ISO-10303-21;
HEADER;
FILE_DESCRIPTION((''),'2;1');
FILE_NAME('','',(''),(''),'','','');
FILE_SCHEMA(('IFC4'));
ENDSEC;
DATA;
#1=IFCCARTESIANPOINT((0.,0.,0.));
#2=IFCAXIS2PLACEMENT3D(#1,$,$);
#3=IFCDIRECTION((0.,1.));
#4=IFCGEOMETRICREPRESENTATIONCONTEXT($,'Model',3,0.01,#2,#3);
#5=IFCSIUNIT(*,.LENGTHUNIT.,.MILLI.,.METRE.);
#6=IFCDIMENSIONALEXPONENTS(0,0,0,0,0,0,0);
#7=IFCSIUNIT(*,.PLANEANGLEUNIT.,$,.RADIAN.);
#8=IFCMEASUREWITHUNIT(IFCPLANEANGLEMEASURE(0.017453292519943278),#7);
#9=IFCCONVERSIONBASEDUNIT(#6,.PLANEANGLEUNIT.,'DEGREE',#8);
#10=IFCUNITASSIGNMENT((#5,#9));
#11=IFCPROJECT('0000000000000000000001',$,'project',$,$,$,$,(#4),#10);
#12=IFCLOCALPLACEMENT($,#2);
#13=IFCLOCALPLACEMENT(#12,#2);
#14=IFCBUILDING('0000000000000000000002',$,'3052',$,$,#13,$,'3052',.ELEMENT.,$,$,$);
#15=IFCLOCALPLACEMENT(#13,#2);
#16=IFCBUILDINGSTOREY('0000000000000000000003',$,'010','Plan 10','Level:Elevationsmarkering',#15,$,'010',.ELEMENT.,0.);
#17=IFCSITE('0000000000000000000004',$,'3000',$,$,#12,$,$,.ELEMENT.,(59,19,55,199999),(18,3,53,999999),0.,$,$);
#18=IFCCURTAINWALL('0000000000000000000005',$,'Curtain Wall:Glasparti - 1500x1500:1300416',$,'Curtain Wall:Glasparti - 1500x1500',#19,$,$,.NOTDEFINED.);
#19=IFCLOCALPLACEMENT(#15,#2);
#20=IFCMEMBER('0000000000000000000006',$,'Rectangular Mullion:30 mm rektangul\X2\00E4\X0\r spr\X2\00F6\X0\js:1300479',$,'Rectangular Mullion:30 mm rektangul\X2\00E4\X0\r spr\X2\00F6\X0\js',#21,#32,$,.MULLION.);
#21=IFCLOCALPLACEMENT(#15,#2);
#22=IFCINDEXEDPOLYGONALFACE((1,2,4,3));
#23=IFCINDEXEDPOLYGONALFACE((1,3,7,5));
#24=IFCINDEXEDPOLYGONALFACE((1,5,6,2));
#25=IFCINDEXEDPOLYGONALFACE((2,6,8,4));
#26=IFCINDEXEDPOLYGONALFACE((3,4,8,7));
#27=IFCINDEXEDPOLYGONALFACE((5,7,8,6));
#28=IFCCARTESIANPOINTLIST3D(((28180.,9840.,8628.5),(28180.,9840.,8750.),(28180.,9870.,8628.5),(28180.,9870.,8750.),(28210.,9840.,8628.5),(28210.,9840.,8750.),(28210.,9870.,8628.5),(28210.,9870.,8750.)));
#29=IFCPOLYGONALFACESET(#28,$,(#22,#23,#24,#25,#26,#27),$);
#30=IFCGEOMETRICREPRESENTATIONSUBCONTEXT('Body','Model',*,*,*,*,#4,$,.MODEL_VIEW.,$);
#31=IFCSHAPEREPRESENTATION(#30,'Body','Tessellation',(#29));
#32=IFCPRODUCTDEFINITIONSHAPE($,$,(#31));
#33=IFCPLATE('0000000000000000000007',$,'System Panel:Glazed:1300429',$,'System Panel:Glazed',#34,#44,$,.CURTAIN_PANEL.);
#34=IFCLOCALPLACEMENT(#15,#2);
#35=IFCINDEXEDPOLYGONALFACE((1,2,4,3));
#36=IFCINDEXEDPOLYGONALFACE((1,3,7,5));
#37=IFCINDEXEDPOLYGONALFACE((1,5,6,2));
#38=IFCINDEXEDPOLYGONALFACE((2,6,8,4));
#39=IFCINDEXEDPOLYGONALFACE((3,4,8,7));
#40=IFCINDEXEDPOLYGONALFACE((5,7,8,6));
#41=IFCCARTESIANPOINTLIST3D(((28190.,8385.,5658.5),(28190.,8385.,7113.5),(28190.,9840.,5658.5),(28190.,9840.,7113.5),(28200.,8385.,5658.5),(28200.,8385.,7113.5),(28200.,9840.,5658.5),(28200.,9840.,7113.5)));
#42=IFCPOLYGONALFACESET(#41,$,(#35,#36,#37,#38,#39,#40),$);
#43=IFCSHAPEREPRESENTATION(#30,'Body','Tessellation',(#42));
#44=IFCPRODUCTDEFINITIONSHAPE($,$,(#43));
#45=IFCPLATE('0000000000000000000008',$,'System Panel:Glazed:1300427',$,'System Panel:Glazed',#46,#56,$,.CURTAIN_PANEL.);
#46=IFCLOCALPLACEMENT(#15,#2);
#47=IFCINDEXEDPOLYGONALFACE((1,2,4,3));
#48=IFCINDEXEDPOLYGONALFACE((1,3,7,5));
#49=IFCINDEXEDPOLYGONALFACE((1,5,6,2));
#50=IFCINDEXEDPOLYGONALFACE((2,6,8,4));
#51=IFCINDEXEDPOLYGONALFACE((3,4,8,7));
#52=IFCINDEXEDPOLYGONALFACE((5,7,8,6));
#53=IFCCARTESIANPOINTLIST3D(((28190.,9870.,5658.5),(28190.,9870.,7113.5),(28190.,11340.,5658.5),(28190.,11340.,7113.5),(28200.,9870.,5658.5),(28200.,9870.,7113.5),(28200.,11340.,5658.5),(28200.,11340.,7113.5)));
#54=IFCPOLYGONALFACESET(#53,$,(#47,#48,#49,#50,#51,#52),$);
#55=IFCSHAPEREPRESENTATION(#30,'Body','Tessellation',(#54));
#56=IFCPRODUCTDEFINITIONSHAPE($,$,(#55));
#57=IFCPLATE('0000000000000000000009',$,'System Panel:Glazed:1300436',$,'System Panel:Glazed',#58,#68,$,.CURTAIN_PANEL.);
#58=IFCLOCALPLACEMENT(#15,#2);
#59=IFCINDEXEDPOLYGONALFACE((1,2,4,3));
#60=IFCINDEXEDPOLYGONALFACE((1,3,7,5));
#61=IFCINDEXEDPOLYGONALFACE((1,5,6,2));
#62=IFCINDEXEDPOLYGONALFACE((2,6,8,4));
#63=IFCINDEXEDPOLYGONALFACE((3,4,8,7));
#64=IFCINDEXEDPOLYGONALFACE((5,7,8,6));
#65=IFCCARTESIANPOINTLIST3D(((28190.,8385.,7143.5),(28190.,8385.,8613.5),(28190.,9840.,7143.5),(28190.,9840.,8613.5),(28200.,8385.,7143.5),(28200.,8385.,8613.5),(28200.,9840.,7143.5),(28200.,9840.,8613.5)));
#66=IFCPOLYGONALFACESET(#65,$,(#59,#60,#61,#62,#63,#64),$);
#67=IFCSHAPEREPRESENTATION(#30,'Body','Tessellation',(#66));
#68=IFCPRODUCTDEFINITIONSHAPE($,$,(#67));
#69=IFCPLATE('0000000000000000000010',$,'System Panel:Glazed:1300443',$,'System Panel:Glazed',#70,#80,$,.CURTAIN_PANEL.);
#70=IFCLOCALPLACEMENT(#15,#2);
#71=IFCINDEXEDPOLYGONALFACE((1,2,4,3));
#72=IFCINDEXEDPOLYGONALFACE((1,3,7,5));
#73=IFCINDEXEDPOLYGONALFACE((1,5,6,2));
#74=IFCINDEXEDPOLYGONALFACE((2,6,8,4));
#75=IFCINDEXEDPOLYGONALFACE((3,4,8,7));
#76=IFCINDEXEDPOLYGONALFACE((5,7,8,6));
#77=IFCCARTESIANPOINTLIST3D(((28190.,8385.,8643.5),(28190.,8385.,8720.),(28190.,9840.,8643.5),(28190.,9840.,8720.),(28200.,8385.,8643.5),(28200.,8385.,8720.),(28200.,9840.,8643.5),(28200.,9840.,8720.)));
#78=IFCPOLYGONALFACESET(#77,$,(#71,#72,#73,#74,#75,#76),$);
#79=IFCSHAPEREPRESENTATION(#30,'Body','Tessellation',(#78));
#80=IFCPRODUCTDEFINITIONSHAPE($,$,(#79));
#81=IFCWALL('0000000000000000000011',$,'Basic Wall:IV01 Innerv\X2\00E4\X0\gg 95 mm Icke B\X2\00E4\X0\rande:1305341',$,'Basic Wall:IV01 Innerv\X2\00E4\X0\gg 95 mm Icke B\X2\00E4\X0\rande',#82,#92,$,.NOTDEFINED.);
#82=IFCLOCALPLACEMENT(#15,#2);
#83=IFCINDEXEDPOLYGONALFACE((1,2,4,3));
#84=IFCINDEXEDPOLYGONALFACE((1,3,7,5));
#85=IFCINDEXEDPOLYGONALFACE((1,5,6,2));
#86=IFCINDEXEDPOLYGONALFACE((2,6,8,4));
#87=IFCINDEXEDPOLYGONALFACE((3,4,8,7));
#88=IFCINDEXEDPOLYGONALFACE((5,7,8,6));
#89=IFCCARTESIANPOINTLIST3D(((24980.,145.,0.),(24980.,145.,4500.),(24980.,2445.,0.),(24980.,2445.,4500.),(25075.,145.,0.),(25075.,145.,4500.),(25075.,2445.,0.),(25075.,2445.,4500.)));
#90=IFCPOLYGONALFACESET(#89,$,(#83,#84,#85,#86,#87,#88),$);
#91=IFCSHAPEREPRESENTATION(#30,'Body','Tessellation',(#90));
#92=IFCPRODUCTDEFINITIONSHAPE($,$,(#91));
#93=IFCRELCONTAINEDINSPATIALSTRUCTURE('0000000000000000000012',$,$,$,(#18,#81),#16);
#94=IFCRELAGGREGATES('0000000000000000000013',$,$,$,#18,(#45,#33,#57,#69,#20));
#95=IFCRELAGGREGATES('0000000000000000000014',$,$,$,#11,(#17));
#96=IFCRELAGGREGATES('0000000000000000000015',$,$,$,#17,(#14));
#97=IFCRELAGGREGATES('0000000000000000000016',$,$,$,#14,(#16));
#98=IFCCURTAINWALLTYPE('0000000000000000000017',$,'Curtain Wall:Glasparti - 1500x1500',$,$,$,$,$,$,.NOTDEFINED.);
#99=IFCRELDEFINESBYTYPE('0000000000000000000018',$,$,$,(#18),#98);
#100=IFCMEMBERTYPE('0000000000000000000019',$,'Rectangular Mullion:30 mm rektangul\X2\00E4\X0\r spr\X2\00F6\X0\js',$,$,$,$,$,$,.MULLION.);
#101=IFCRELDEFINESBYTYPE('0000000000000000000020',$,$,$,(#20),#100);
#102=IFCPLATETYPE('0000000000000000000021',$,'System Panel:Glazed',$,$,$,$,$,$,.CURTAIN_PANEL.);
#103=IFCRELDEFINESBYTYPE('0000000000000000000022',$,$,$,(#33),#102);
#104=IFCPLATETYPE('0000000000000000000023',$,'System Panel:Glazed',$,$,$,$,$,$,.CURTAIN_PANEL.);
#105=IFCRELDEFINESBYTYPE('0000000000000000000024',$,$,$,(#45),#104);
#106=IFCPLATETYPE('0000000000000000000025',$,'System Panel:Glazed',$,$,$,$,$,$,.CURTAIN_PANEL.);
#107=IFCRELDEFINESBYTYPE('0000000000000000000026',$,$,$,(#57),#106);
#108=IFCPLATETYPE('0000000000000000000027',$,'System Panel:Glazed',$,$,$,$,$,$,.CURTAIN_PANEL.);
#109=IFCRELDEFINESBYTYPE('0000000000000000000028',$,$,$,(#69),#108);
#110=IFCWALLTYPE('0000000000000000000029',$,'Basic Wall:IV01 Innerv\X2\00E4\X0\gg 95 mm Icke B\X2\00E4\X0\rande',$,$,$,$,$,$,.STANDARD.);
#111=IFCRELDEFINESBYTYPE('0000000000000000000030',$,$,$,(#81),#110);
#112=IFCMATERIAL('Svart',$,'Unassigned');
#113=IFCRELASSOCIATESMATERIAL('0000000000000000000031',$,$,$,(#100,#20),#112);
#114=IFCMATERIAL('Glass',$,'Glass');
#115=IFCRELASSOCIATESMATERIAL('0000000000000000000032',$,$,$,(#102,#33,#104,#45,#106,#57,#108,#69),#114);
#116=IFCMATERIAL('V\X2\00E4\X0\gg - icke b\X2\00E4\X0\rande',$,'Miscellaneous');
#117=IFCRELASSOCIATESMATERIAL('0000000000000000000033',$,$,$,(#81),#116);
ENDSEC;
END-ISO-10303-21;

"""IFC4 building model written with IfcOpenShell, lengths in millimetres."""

from ifc_helpers import new_model, entity, si_unit, converted_unit, direction, frame, origin, place, context, subcontext, project, spatial, indexed_curve, outline, extrude, source, transform, mapped, material, type_object, type_shapes, element, aggregate, save


model = new_model("IFC4")

# Units and contexts
model_context = context("Model", 3, precision=0.01, world=origin(), true_north=direction((0.0, 1.0)))
body_context = subcontext(model_context, "Body", "Model", "MODEL_VIEW")
ifc_project = project(units=[si_unit("LENGTHUNIT", "METRE", prefix="MILLI"), converted_unit("PLANEANGLEUNIT", "DEGREE", entity("IfcPlaneAngleMeasure", 0.017453292519943278), si_unit("PLANEANGLEUNIT", "RADIAN"), dimensions=[0, 0, 0, 0, 0, 0, 0])], contexts=[model_context])

# Site, building, storey
site_placement = place(None, origin())
site = spatial("IfcSite", under=ifc_project, at=site_placement, Name="3000", CompositionType="ELEMENT", RefLatitude=(59, 19, 55, 199999), RefLongitude=(18, 3, 53, 999999), RefElevation=0.0)
building_placement = place(site_placement, origin())
building = spatial("IfcBuilding", under=site, at=building_placement, Name="3052", LongName="3052", CompositionType="ELEMENT")
storey_placement = place(building_placement, origin())
storey = spatial("IfcBuildingStorey", under=building, at=storey_placement, Name="010", Description="Plan 10", ObjectType="Level:Elevationsmarkering", LongName="010", CompositionType="ELEMENT", Elevation=0.0)

# Curtain wall, member, plates
curtain_wall_type = type_object("IfcCurtainWallType", Name="Curtain Wall:Glasparti - 1500x1500", PredefinedType="NOTDEFINED")
curtain_wall_placement = place(storey_placement, origin())
curtain_wall = element("IfcCurtainWall", 1, at=curtain_wall_placement, inside=storey, type_object=curtain_wall_type, Name="Curtain Wall:Glasparti - 1500x1500:1300416", ObjectType="Curtain Wall:Glasparti - 1500x1500", PredefinedType="NOTDEFINED")
ifc_material_1 = material(Name="Svart", Category="Unassigned")
member_type_1 = type_object("IfcMemberType", Name="Rectangular Mullion:30 mm rektangulär spröjs", PredefinedType="MULLION", material=ifc_material_1)
shared_shape_1 = source(origin(), body_context, "Body", "SweptSolid", [
    extrude(outline(indexed_curve([(-15.0, -15.0), (15.0, -15.0), (15.0, 15.0), (-15.0, 15.0), (-15.0, -15.0)], self_intersect=False)), frame((0.0, 0.0, -121.5), z_axis=(0.0, 0.0, 1.0), x_axis=(-1.0, 0.0, 0.0)), (0.0, 0.0, 1.0), 121.5),
])
type_shapes(member_type_1, [shared_shape_1])
member_1_placement = place(curtain_wall_placement, frame((28195.0, 9855.0, 8628.5), z_axis=(0.0, 0.0, -1.0), x_axis=(0.0, -1.0, 0.0)))
member_1 = element("IfcMember", 2, at=member_1_placement, type_object=member_type_1, material=ifc_material_1, Name="Rectangular Mullion:30 mm rektangulär spröjs:1300479", ObjectType="Rectangular Mullion:30 mm rektangulär spröjs", PredefinedType="MULLION", context=body_context, shape_type="MappedRepresentation", body=[
    mapped(shared_shape_1, transform((0.0, 0.0, 0.0), scale=1.0)),
])
ifc_material_2 = material(Name="Glass", Category="Glass")
plate_type_1 = type_object("IfcPlateType", Name="System Panel:Glazed", PredefinedType="CURTAIN_PANEL", material=ifc_material_2)
shared_shape_2 = source(origin(), body_context, "Body", "SweptSolid", [
    extrude(outline(indexed_curve([(-5.0, -727.5), (5.0, -727.5), (5.0, 727.5), (-5.0, 727.5), (-5.0, -727.5)], self_intersect=False)), frame((0.0, 0.0, 0.0), z_axis=(0.0, 0.0, 1.0), x_axis=(0.0, 1.0, 0.0)), (0.0, 0.0, 1.0), 1455.0),
])
type_shapes(plate_type_1, [shared_shape_2])
plate_1_placement = place(curtain_wall_placement, frame((28195.0, 9112.5, 5658.5), z_axis=(0.0, 0.0, 1.0), x_axis=(0.0, -1.0, 0.0)))
plate_1 = element("IfcPlate", 3, at=plate_1_placement, type_object=plate_type_1, material=ifc_material_2, Name="System Panel:Glazed:1300429", ObjectType="System Panel:Glazed", PredefinedType="CURTAIN_PANEL", context=body_context, shape_type="MappedRepresentation", body=[
    mapped(shared_shape_2, transform((0.0, 0.0, 0.0), scale=1.0)),
])
plate_type_2 = type_object("IfcPlateType", Name="System Panel:Glazed", PredefinedType="CURTAIN_PANEL", material=ifc_material_2)
shared_shape_3 = source(origin(), body_context, "Body", "SweptSolid", [
    extrude(outline(indexed_curve([(-5.0, -735.0), (5.0, -735.0), (5.0, 735.0), (-5.0, 735.0), (-5.0, -735.0)], self_intersect=False)), frame((0.0, 0.0, 0.0), z_axis=(0.0, 0.0, 1.0), x_axis=(0.0, 1.0, 0.0)), (0.0, 0.0, 1.0), 1455.0),
])
type_shapes(plate_type_2, [shared_shape_3])
plate_2_placement = place(curtain_wall_placement, frame((28195.0, 10605.0, 5658.5), z_axis=(0.0, 0.0, 1.0), x_axis=(0.0, -1.0, 0.0)))
plate_2 = element("IfcPlate", 4, at=plate_2_placement, type_object=plate_type_2, material=ifc_material_2, Name="System Panel:Glazed:1300427", ObjectType="System Panel:Glazed", PredefinedType="CURTAIN_PANEL", context=body_context, shape_type="MappedRepresentation", body=[
    mapped(shared_shape_3, transform((0.0, 0.0, 0.0), scale=1.0)),
])
plate_type_3 = type_object("IfcPlateType", Name="System Panel:Glazed", PredefinedType="CURTAIN_PANEL", material=ifc_material_2)
shared_shape_4 = source(origin(), body_context, "Body", "SweptSolid", [
    extrude(outline(indexed_curve([(-5.0, -727.5), (5.0, -727.5), (5.0, 727.5), (-5.0, 727.5), (-5.0, -727.5)], self_intersect=False)), frame((0.0, 0.0, 0.0), z_axis=(0.0, 0.0, 1.0), x_axis=(0.0, 1.0, 0.0)), (0.0, 0.0, 1.0), 1470.0),
])
type_shapes(plate_type_3, [shared_shape_4])
plate_3_placement = place(curtain_wall_placement, frame((28195.0, 9112.5, 7143.5), z_axis=(0.0, 0.0, 1.0), x_axis=(0.0, -1.0, 0.0)))
plate_3 = element("IfcPlate", 5, at=plate_3_placement, type_object=plate_type_3, material=ifc_material_2, Name="System Panel:Glazed:1300436", ObjectType="System Panel:Glazed", PredefinedType="CURTAIN_PANEL", context=body_context, shape_type="MappedRepresentation", body=[
    mapped(shared_shape_4, transform((0.0, 0.0, 0.0), scale=1.0)),
])
plate_type_4 = type_object("IfcPlateType", Name="System Panel:Glazed", PredefinedType="CURTAIN_PANEL", material=ifc_material_2)
shared_shape_5 = source(origin(), body_context, "Body", "SweptSolid", [
    extrude(outline(indexed_curve([(-5.0, -727.5), (5.0, -727.5), (5.0, 727.5), (-5.0, 727.5), (-5.0, -727.5)], self_intersect=False)), frame((0.0, 0.0, 0.0), z_axis=(0.0, 0.0, 1.0), x_axis=(0.0, 1.0, 0.0)), (0.0, 0.0, 1.0), 76.5),
])
type_shapes(plate_type_4, [shared_shape_5])
plate_4_placement = place(curtain_wall_placement, frame((28195.0, 9112.5, 8643.5), z_axis=(0.0, 0.0, 1.0), x_axis=(0.0, -1.0, 0.0)))
plate_4 = element("IfcPlate", 6, at=plate_4_placement, type_object=plate_type_4, material=ifc_material_2, Name="System Panel:Glazed:1300443", ObjectType="System Panel:Glazed", PredefinedType="CURTAIN_PANEL", context=body_context, shape_type="MappedRepresentation", body=[
    mapped(shared_shape_5, transform((0.0, 0.0, 0.0), scale=1.0)),
])
aggregate(curtain_wall, [plate_2, plate_1, plate_3, plate_4, member_1])

# Wall
ifc_material_3 = material(Name="Vägg - icke bärande", Category="Miscellaneous")
wall_type = type_object("IfcWallType", Name="Basic Wall:IV01 Innervägg 95 mm Icke Bärande", PredefinedType="STANDARD")
wall_placement = place(storey_placement, frame((25027.5, 2445.0, 0.0), z_axis=(0.0, 0.0, 1.0), x_axis=(0.0, -1.0, 0.0)))
element("IfcWall", 7, at=wall_placement, inside=storey, type_object=wall_type, material=ifc_material_3, Name="Basic Wall:IV01 Innervägg 95 mm Icke Bärande:1305341", ObjectType="Basic Wall:IV01 Innervägg 95 mm Icke Bärande", PredefinedType="NOTDEFINED", context=body_context, shape_type="SweptSolid", body=[
    extrude(outline(indexed_curve([(2300.0, 47.5), (0.0, 47.5), (0.0, -47.5), (2300.0, -47.5), (2300.0, 47.5)], self_intersect=False)), origin(), (0.0, 0.0, 1.0), 4500.0),
])

save(model, "model.ifc")
